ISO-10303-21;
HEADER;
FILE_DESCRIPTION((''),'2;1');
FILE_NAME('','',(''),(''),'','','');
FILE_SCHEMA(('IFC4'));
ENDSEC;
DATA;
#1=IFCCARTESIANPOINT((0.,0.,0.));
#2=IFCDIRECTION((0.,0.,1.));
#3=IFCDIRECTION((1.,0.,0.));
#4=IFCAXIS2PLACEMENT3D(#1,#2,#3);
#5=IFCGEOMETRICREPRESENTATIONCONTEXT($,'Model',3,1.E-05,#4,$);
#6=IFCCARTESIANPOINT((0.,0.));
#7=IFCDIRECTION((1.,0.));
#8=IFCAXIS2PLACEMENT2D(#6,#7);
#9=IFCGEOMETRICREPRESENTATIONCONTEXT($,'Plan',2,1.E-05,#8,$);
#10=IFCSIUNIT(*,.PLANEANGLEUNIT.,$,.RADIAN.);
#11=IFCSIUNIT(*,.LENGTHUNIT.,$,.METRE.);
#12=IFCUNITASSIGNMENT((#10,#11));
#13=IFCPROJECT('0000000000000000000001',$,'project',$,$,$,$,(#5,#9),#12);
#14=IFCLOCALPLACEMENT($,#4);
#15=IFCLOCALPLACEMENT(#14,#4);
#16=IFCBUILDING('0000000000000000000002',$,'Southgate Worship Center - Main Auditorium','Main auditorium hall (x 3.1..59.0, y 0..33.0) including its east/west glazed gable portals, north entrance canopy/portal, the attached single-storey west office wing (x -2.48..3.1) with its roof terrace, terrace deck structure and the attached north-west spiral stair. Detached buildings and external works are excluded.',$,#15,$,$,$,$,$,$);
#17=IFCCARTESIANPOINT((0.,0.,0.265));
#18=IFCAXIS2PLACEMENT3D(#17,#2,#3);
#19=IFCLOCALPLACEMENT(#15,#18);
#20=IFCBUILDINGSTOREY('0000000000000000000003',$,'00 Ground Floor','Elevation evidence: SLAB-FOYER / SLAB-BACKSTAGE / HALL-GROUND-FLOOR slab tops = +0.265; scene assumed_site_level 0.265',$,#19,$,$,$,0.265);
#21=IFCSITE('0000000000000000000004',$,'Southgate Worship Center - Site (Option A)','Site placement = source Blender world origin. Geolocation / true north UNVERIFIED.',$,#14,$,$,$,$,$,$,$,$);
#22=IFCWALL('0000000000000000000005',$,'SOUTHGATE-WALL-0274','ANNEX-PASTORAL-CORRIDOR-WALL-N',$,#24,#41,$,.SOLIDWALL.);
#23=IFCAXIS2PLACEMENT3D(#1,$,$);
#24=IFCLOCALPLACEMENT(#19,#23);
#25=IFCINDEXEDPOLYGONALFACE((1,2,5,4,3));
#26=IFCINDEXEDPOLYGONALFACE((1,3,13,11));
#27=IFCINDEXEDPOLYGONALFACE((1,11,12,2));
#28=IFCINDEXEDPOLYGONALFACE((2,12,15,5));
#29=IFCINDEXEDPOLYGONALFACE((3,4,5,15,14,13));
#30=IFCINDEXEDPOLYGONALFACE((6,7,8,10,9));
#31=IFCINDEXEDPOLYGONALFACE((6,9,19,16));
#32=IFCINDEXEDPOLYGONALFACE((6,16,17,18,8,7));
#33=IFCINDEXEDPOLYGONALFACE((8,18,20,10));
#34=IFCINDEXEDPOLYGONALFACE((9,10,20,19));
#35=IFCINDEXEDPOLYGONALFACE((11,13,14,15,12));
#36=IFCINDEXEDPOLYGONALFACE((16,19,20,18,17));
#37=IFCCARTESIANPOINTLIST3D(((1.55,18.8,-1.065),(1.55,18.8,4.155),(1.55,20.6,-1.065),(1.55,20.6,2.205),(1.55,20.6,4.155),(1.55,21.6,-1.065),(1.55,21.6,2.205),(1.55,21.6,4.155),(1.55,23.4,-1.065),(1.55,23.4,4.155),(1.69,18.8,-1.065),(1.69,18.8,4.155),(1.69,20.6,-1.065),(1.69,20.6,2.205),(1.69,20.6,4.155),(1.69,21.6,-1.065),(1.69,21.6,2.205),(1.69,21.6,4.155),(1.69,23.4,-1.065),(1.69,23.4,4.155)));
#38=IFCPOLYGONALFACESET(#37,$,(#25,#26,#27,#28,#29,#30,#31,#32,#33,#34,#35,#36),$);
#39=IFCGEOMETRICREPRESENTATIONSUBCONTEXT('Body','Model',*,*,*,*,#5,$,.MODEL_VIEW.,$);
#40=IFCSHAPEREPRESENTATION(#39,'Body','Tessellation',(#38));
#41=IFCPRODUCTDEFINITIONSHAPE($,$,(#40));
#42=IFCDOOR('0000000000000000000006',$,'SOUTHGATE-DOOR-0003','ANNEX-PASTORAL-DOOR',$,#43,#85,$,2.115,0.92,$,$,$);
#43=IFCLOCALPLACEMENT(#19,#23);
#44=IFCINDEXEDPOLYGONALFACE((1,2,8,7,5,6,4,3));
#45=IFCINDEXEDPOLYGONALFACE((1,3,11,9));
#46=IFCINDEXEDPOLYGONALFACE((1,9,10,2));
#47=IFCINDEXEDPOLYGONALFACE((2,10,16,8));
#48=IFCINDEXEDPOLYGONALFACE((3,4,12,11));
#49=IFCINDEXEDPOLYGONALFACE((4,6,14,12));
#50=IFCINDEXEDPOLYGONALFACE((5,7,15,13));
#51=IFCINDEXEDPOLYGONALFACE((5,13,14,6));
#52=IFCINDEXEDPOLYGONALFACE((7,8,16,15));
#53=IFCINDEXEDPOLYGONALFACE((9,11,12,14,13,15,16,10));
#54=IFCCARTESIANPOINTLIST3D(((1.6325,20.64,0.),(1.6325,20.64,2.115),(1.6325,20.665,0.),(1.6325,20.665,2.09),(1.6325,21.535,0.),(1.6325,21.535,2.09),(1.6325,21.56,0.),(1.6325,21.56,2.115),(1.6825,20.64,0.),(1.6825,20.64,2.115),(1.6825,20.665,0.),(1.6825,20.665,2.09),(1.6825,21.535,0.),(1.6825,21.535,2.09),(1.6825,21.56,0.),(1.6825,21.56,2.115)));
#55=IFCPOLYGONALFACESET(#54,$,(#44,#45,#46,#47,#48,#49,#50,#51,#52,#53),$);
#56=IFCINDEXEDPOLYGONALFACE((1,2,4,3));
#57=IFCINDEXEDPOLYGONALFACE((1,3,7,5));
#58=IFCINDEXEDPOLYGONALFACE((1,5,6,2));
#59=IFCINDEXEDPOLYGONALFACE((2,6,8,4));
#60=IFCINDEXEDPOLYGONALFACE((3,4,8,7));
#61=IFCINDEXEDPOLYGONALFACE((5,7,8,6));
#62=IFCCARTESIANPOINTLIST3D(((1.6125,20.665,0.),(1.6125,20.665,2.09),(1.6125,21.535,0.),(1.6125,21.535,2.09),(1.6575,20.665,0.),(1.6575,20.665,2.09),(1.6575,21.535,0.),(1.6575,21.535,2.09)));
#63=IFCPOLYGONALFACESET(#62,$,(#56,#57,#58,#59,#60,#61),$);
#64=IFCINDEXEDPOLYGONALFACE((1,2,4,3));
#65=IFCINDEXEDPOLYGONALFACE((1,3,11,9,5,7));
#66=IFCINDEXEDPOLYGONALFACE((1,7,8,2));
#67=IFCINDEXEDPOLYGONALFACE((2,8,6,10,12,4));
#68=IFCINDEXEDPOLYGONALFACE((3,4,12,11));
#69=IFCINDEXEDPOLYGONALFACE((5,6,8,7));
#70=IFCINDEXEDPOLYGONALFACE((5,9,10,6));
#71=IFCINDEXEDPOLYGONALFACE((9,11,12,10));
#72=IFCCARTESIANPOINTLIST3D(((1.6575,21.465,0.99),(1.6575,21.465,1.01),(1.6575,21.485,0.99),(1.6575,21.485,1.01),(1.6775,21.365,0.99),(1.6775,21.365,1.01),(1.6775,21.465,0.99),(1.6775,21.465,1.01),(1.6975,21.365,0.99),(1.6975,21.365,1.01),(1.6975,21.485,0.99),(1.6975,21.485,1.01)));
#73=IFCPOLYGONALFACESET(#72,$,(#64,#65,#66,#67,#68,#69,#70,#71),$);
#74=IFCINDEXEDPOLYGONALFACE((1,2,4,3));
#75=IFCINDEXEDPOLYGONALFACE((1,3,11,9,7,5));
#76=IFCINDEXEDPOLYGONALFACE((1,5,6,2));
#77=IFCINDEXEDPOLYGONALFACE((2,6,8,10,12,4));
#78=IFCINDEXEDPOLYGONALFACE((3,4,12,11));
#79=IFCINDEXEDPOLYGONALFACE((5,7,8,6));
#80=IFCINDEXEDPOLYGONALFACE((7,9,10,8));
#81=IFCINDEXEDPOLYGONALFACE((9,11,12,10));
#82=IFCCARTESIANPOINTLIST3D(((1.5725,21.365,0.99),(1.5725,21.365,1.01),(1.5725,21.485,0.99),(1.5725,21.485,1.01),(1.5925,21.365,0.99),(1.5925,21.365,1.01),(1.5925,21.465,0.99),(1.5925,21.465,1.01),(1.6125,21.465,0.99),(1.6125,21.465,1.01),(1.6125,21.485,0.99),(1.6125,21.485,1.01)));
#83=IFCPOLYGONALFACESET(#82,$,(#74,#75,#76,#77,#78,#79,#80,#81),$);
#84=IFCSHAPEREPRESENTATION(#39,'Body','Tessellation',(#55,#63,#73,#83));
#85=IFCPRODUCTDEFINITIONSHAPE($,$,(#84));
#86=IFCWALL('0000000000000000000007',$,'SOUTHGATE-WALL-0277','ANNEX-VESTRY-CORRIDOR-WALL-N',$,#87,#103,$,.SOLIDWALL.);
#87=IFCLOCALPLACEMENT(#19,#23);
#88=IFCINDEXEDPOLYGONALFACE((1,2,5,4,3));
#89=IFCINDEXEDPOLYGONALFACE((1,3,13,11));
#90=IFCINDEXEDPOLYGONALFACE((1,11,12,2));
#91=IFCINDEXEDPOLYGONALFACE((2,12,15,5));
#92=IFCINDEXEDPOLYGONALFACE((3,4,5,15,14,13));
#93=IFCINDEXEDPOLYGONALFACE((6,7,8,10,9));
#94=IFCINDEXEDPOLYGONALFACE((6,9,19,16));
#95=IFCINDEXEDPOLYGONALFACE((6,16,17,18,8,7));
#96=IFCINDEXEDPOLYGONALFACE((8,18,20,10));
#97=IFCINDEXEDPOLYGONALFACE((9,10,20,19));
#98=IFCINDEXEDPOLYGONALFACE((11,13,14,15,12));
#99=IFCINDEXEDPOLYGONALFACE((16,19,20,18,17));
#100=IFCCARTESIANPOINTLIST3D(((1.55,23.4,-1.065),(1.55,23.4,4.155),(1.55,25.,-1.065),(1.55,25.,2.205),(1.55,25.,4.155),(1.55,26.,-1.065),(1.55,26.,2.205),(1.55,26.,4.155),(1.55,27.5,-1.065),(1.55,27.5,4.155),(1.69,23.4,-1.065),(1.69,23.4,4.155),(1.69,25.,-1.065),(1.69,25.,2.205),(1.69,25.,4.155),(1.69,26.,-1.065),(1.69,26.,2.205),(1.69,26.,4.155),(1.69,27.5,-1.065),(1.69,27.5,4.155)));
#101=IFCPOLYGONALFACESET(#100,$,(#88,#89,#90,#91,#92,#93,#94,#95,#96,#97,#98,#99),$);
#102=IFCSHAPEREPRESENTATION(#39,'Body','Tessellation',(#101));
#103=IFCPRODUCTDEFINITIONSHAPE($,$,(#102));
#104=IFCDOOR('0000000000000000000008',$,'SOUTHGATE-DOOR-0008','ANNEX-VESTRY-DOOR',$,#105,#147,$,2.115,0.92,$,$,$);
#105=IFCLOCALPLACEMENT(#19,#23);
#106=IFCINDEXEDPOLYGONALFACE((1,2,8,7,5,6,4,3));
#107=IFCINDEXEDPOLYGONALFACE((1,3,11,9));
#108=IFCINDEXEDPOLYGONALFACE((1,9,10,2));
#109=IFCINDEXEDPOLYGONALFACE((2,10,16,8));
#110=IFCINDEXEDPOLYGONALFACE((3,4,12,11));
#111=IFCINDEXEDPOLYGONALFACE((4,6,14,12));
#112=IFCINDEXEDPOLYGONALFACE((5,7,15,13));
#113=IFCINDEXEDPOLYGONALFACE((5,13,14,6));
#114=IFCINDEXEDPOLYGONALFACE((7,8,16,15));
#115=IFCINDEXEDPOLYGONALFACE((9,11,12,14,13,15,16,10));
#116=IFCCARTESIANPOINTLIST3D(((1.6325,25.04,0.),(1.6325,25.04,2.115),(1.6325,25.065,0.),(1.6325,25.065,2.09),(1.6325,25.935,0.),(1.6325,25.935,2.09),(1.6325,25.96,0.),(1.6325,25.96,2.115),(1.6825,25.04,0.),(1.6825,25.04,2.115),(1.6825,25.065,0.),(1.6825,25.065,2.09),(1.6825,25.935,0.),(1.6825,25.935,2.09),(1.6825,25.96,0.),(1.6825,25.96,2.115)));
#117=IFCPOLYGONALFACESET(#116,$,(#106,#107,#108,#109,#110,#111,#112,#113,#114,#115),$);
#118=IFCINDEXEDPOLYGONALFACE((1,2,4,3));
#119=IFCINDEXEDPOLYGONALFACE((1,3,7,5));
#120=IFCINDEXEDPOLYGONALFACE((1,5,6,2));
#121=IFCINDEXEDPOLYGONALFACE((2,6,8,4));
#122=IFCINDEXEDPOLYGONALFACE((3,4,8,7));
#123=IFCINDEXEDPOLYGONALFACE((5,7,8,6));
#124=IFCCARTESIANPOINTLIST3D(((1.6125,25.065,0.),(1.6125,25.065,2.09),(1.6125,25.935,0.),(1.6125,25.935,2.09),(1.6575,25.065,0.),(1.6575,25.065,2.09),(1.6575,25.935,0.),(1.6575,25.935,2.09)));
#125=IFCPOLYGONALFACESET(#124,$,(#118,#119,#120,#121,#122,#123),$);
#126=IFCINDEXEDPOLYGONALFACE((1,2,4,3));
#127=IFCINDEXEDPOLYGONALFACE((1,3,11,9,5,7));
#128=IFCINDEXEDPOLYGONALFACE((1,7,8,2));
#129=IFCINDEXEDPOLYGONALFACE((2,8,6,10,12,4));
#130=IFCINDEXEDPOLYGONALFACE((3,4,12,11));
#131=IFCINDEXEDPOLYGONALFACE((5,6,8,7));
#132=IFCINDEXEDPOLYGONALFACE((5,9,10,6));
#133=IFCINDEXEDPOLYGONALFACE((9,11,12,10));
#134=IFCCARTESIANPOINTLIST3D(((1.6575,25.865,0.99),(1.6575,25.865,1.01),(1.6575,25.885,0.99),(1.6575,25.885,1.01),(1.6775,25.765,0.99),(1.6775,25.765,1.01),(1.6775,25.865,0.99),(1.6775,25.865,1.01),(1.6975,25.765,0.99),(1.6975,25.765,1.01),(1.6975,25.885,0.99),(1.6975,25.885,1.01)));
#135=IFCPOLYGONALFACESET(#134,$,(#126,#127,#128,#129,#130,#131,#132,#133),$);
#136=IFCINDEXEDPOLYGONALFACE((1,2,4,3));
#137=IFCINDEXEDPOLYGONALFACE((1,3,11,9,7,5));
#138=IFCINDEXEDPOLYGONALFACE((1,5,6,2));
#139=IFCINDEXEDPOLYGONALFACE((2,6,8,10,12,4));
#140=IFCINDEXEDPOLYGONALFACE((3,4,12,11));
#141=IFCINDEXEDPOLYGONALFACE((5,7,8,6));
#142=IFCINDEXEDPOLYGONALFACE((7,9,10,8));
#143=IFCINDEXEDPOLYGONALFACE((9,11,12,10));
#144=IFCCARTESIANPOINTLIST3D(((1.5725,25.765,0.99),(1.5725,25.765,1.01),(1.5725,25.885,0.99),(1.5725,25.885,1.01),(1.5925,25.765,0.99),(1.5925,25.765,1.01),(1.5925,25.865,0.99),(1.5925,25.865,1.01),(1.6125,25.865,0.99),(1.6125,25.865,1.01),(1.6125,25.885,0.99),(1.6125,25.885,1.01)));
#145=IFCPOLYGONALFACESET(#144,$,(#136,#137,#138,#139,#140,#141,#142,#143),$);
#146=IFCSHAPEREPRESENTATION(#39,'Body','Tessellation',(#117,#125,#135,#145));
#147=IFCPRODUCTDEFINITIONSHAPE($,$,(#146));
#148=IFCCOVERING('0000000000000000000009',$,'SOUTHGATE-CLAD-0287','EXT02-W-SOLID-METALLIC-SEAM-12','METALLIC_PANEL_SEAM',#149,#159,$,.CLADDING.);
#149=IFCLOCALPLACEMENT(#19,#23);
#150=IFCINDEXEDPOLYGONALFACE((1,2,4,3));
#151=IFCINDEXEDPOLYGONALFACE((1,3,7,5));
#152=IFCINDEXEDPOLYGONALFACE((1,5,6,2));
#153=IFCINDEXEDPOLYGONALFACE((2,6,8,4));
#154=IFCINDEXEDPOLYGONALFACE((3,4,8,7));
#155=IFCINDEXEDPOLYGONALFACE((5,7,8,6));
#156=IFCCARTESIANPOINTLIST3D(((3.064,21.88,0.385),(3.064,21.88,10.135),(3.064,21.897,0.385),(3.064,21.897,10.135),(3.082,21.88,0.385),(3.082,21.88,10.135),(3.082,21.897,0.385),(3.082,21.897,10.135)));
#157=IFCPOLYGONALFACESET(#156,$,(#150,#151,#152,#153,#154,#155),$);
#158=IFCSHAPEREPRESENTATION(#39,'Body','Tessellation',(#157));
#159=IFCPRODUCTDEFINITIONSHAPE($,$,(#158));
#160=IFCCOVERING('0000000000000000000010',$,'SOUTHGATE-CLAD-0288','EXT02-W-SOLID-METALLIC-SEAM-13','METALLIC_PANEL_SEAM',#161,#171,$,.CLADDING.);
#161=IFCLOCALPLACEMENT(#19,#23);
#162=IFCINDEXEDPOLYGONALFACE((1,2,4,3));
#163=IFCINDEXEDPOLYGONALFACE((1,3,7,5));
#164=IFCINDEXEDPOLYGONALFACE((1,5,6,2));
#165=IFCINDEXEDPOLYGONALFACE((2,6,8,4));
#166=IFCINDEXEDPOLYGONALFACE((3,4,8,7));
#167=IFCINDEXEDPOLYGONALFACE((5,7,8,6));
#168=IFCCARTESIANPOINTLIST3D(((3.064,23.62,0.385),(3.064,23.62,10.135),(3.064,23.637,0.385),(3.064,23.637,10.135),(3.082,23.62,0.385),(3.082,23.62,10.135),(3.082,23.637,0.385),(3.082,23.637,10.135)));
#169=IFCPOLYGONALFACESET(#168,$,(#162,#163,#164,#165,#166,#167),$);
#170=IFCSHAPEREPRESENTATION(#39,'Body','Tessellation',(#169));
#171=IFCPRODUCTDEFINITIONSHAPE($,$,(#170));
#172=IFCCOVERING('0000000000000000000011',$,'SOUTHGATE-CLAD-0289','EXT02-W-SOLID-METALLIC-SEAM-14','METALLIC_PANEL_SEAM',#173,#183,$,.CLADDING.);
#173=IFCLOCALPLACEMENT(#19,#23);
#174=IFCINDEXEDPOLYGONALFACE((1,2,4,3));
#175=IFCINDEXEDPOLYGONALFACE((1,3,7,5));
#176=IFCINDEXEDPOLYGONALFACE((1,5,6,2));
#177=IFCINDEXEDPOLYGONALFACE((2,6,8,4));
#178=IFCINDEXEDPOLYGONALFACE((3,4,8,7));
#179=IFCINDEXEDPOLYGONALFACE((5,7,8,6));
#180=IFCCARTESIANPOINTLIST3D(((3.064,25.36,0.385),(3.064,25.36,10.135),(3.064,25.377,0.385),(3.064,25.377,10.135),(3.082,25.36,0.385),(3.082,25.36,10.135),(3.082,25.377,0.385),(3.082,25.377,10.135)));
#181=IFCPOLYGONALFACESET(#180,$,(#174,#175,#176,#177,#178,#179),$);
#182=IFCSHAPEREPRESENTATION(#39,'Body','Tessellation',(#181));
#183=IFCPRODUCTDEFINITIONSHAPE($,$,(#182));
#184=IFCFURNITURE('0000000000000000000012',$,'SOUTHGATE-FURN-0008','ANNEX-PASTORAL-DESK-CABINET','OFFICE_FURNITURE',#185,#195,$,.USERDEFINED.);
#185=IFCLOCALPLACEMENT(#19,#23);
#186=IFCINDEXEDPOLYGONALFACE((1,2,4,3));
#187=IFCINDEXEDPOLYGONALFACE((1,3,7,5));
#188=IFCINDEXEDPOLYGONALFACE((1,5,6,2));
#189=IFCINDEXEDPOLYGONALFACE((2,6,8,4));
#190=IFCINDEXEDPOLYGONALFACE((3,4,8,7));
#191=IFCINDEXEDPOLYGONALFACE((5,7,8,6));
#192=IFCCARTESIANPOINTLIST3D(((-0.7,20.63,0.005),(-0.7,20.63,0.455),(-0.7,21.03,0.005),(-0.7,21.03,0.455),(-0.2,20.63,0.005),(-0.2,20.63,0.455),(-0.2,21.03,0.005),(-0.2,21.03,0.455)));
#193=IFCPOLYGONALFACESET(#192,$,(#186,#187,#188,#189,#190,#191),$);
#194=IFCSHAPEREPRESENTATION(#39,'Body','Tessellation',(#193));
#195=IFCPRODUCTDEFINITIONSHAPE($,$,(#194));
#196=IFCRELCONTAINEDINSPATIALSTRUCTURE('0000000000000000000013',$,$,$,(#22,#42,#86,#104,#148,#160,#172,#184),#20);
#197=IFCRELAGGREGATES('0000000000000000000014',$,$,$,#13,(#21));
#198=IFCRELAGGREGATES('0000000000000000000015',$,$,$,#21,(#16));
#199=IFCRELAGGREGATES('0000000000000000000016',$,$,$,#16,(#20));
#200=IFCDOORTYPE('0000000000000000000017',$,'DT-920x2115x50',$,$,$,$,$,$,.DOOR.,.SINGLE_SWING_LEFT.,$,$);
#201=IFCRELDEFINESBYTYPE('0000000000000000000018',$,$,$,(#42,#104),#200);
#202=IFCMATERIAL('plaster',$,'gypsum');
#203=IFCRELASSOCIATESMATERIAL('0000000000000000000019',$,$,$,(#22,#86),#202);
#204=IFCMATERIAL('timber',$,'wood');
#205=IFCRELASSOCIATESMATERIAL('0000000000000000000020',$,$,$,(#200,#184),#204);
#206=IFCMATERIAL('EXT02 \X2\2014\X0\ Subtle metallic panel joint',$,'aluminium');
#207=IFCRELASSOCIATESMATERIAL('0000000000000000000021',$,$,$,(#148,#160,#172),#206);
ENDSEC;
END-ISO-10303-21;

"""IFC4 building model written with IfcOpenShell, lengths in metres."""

from ifc_helpers import new_model, si_unit, frame, frame_2d, origin_with_axes, origin_2d, origin_2d_with_axis, place, context, subcontext, project, spatial, line, indexed_curve, rectangle, outline, extrude, source, transform, mapped, material, type_object, type_shapes, element, fill, save


model = new_model("IFC4")

# Units and contexts
model_context = context("Model", 3, precision=1e-05, world=origin_with_axes())
plan_context = context("Plan", 2, precision=1e-05, world=origin_2d_with_axis())
body_context = subcontext(model_context, "Body", "Model", "MODEL_VIEW")
ifc_project = project(units=[si_unit("PLANEANGLEUNIT", "RADIAN"), si_unit("LENGTHUNIT", "METRE")], contexts=[model_context, plan_context])

# Site, building, storey
site_placement = place(None, origin_with_axes())
site = spatial("IfcSite", under=ifc_project, at=site_placement, Name="Southgate Worship Center - Site (Option A)", Description="Site placement = source Blender world origin. Geolocation / true north UNVERIFIED.")
building_placement = place(site_placement, origin_with_axes())
building = spatial("IfcBuilding", under=site, at=building_placement, Name="Southgate Worship Center - Main Auditorium", Description="Main auditorium hall (x 3.1..59.0, y 0..33.0) including its east/west glazed gable portals, north entrance canopy/portal, the attached single-storey west office wing (x -2.48..3.1) with its roof terrace, terrace deck structure and the attached north-west spiral stair. Detached buildings and external works are excluded.")
storey_placement = place(building_placement, frame((0.0, 0.0, 0.265), z_axis=(0.0, 0.0, 1.0), x_axis=(1.0, 0.0, 0.0)))
storey = spatial("IfcBuildingStorey", under=building, at=storey_placement, Name="00 Ground Floor", Description="Elevation evidence: SLAB-FOYER / SLAB-BACKSTAGE / HALL-GROUND-FLOOR slab tops = +0.265; scene assumed_site_level 0.265", Elevation=0.265)

# Shared definitions
ifc_material_1 = material(Name="plaster", Category="gypsum")

# Walls, openings, doors
wall_1_placement = place(storey_placement, frame((1.69, 18.8, -1.065), z_axis=(0.0, 0.0, 1.0), x_axis=(0.0, 1.0, 0.0)))
wall_1 = element("IfcWall", 1, at=wall_1_placement, inside=storey, material=ifc_material_1, Name="SOUTHGATE-WALL-0274", Description="ANNEX-PASTORAL-CORRIDOR-WALL-N", PredefinedType="SOLIDWALL", context=body_context, shape_type="SweptSolid", body=[
    extrude(outline(indexed_curve([(0.0, 0.0), (4.6, 0.0), (4.6, 5.22), (2.8, 5.22), (2.8, 3.27), (1.8, 3.27), (1.8, 5.22), (0.0, 5.22), (0.0, 0.0)], self_intersect=False)), frame((0.0, 0.0, 0.0), z_axis=(0.0, -1.0, 0.0), x_axis=(1.0, 0.0, 0.0)), (0.0, 0.0, -1.0), 0.14),
])
opening_1_placement = place(wall_1_placement, origin_with_axes())
opening_1 = element("IfcOpeningElement", 2, at=opening_1_placement, cuts=wall_1, PredefinedType="OPENING", context=body_context, shape_type="SweptSolid", body=[
    extrude(rectangle(XDim=1.0, YDim=0.24, at=frame_2d((2.3, 0.07))), origin_with_axes(), (0.0, 0.0, 1.0), 3.27),
])
ifc_material_2 = material(Name="timber", Category="wood")
door_type = type_object("IfcDoorType", Name="DT-920x2115x50", OperationType="SINGLE_SWING_LEFT", PredefinedType="DOOR", material=ifc_material_2)
shared_shape_1 = source(origin_with_axes(), body_context, "Body", "SweptSolid", [
    extrude(outline(indexed_curve([(0.0, 0.0), (0.0, 2.115), (0.92, 2.115), (0.92, 0.0), (0.895, 0.0), (0.895, 2.09), (0.025, 2.09), (0.025, 0.0)], segments=[line(1, 2, 3, 4, 5, 6, 7, 8, 1)])), frame((0.0, 0.0, 0.0), z_axis=(0.0, -1.0, 0.0), x_axis=(1.0, 0.0, 0.0)), (0.0, 0.0, -1.0), 0.05),
    extrude(outline(indexed_curve([(0.0, 0.0), (0.87, 0.0), (0.87, 0.045), (0.0, 0.045)], segments=[line(1, 2, 3, 4, 1)])), frame((0.025, 0.025, 0.0), z_axis=(0.0, 0.0, 1.0), x_axis=(1.0, 0.0, 0.0)), (0.0, 0.0, 1.0), 2.09),
    extrude(outline(indexed_curve([(0.0, 0.0), (0.0, -0.04), (-0.12, -0.04), (-0.12, -0.02), (-0.02, -0.02), (-0.02, 0.0)], segments=[line(1, 2, 3, 4, 5, 6, 1)])), frame((0.845, 0.025, 0.99), z_axis=(0.0, 0.0, 1.0), x_axis=(1.0, 0.0, 0.0)), (0.0, 0.0, 1.0), 0.02),
    extrude(outline(indexed_curve([(0.0, 0.0), (0.0, 0.04), (-0.12, 0.04), (-0.12, 0.02), (-0.02, 0.02), (-0.02, 0.0)], segments=[line(1, 2, 3, 4, 5, 6, 1)])), frame((0.845, 0.07, 0.99), z_axis=(0.0, 0.0, 1.0), x_axis=(1.0, 0.0, 0.0)), (0.0, 0.0, 1.0), 0.02),
])
type_shapes(door_type, [shared_shape_1])
door_1_placement = place(storey_placement, frame((1.6825, 20.64, 0.0), z_axis=(0.0, 0.0, 1.0), x_axis=(0.0, 1.0, 0.0)))
door_1 = element("IfcDoor", 3, at=door_1_placement, inside=storey, type_object=door_type, Name="SOUTHGATE-DOOR-0003", Description="ANNEX-PASTORAL-DOOR", OverallHeight=2.115, OverallWidth=0.92, context=body_context, shape_type="MappedRepresentation", body=[
    mapped(shared_shape_1, transform((0.0, 0.0, 0.0), x_axis=(1.0, 0.0, 0.0), y_axis=(0.0, 1.0, 0.0), z_axis=(0.0, 0.0, 1.0), scale=1.0)),
])
fill(opening_1, door_1)
wall_2_placement = place(storey_placement, frame((1.69, 23.4, -1.065), z_axis=(0.0, 0.0, 1.0), x_axis=(0.0, 1.0, 0.0)))
wall_2 = element("IfcWall", 4, at=wall_2_placement, inside=storey, material=ifc_material_1, Name="SOUTHGATE-WALL-0277", Description="ANNEX-VESTRY-CORRIDOR-WALL-N", PredefinedType="SOLIDWALL", context=body_context, shape_type="SweptSolid", body=[
    extrude(outline(indexed_curve([(0.0, 0.0), (4.1, 0.0), (4.1, 5.22), (2.6, 5.22), (2.6, 3.27), (1.6, 3.27), (1.6, 5.22), (0.0, 5.22), (0.0, 0.0)], self_intersect=False)), frame((0.0, 0.0, 0.0), z_axis=(0.0, -1.0, 0.0), x_axis=(1.0, 0.0, 0.0)), (0.0, 0.0, -1.0), 0.14),
])
opening_2_placement = place(wall_2_placement, origin_with_axes())
opening_2 = element("IfcOpeningElement", 5, at=opening_2_placement, cuts=wall_2, PredefinedType="OPENING", context=body_context, shape_type="SweptSolid", body=[
    extrude(rectangle(XDim=1.0, YDim=0.24, at=frame_2d((2.1, 0.07))), origin_with_axes(), (0.0, 0.0, 1.0), 3.27),
])
door_2_placement = place(storey_placement, frame((1.6825, 25.04, 0.0), z_axis=(0.0, 0.0, 1.0), x_axis=(0.0, 1.0, 0.0)))
door_2 = element("IfcDoor", 6, at=door_2_placement, inside=storey, type_object=door_type, Name="SOUTHGATE-DOOR-0008", Description="ANNEX-VESTRY-DOOR", OverallHeight=2.115, OverallWidth=0.92, context=body_context, shape_type="MappedRepresentation", body=[
    mapped(shared_shape_1, transform((0.0, 0.0, 0.0), x_axis=(1.0, 0.0, 0.0), y_axis=(0.0, 1.0, 0.0), z_axis=(0.0, 0.0, 1.0), scale=1.0)),
])
fill(opening_2, door_2)

# Coverings
ifc_material_3 = material(Name="EXT02 — Subtle metallic panel joint", Category="aluminium")
covering_1_placement = place(storey_placement, frame((3.064, 21.88, 0.385), z_axis=(0.0, 0.0, 1.0), x_axis=(1.0, 0.0, 0.0)))
element("IfcCovering", 7, at=covering_1_placement, inside=storey, material=ifc_material_3, Name="SOUTHGATE-CLAD-0287", Description="EXT02-W-SOLID-METALLIC-SEAM-12", ObjectType="METALLIC_PANEL_SEAM", PredefinedType="CLADDING", context=body_context, shape_type="SweptSolid", body=[
    extrude(rectangle(XDim=0.017, YDim=0.018, at=origin_2d()), frame((0.009, 0.0085, 0.0), z_axis=(0.0, 0.0, 1.0), x_axis=(0.0, 1.0, 0.0)), (0.0, 0.0, 1.0), 9.75),
])
covering_2_placement = place(storey_placement, frame((3.064, 23.62, 0.385), z_axis=(0.0, 0.0, 1.0), x_axis=(1.0, 0.0, 0.0)))
element("IfcCovering", 8, at=covering_2_placement, inside=storey, material=ifc_material_3, Name="SOUTHGATE-CLAD-0288", Description="EXT02-W-SOLID-METALLIC-SEAM-13", ObjectType="METALLIC_PANEL_SEAM", PredefinedType="CLADDING", context=body_context, shape_type="SweptSolid", body=[
    extrude(rectangle(XDim=0.017, YDim=0.018, at=origin_2d()), frame((0.009, 0.0085, 0.0), z_axis=(0.0, 0.0, 1.0), x_axis=(0.0, 1.0, 0.0)), (0.0, 0.0, 1.0), 9.75),
])
covering_3_placement = place(storey_placement, frame((3.064, 25.36, 0.385), z_axis=(0.0, 0.0, 1.0), x_axis=(1.0, 0.0, 0.0)))
element("IfcCovering", 9, at=covering_3_placement, inside=storey, material=ifc_material_3, Name="SOUTHGATE-CLAD-0289", Description="EXT02-W-SOLID-METALLIC-SEAM-14", ObjectType="METALLIC_PANEL_SEAM", PredefinedType="CLADDING", context=body_context, shape_type="SweptSolid", body=[
    extrude(rectangle(XDim=0.017, YDim=0.018, at=origin_2d()), frame((0.009, 0.0085, 0.0), z_axis=(0.0, 0.0, 1.0), x_axis=(0.0, 1.0, 0.0)), (0.0, 0.0, 1.0), 9.75),
])

# Furniture
furniture_1_placement = place(storey_placement, frame((-0.7, 20.63, 0.005), z_axis=(0.0, 0.0, 1.0), x_axis=(1.0, 0.0, 0.0)))
element("IfcFurniture", 10, at=furniture_1_placement, inside=storey, material=ifc_material_2, Name="SOUTHGATE-FURN-0008", Description="ANNEX-PASTORAL-DESK-CABINET", ObjectType="OFFICE_FURNITURE", PredefinedType="USERDEFINED", context=body_context, shape_type="SweptSolid", body=[
    extrude(rectangle(XDim=0.4, YDim=0.5, at=origin_2d()), frame((0.25, 0.2, 0.0), z_axis=(0.0, 0.0, 1.0), x_axis=(0.0, -1.0, 0.0)), (0.0, 0.0, 1.0), 0.45),
])

save(model, "model.ifc")
